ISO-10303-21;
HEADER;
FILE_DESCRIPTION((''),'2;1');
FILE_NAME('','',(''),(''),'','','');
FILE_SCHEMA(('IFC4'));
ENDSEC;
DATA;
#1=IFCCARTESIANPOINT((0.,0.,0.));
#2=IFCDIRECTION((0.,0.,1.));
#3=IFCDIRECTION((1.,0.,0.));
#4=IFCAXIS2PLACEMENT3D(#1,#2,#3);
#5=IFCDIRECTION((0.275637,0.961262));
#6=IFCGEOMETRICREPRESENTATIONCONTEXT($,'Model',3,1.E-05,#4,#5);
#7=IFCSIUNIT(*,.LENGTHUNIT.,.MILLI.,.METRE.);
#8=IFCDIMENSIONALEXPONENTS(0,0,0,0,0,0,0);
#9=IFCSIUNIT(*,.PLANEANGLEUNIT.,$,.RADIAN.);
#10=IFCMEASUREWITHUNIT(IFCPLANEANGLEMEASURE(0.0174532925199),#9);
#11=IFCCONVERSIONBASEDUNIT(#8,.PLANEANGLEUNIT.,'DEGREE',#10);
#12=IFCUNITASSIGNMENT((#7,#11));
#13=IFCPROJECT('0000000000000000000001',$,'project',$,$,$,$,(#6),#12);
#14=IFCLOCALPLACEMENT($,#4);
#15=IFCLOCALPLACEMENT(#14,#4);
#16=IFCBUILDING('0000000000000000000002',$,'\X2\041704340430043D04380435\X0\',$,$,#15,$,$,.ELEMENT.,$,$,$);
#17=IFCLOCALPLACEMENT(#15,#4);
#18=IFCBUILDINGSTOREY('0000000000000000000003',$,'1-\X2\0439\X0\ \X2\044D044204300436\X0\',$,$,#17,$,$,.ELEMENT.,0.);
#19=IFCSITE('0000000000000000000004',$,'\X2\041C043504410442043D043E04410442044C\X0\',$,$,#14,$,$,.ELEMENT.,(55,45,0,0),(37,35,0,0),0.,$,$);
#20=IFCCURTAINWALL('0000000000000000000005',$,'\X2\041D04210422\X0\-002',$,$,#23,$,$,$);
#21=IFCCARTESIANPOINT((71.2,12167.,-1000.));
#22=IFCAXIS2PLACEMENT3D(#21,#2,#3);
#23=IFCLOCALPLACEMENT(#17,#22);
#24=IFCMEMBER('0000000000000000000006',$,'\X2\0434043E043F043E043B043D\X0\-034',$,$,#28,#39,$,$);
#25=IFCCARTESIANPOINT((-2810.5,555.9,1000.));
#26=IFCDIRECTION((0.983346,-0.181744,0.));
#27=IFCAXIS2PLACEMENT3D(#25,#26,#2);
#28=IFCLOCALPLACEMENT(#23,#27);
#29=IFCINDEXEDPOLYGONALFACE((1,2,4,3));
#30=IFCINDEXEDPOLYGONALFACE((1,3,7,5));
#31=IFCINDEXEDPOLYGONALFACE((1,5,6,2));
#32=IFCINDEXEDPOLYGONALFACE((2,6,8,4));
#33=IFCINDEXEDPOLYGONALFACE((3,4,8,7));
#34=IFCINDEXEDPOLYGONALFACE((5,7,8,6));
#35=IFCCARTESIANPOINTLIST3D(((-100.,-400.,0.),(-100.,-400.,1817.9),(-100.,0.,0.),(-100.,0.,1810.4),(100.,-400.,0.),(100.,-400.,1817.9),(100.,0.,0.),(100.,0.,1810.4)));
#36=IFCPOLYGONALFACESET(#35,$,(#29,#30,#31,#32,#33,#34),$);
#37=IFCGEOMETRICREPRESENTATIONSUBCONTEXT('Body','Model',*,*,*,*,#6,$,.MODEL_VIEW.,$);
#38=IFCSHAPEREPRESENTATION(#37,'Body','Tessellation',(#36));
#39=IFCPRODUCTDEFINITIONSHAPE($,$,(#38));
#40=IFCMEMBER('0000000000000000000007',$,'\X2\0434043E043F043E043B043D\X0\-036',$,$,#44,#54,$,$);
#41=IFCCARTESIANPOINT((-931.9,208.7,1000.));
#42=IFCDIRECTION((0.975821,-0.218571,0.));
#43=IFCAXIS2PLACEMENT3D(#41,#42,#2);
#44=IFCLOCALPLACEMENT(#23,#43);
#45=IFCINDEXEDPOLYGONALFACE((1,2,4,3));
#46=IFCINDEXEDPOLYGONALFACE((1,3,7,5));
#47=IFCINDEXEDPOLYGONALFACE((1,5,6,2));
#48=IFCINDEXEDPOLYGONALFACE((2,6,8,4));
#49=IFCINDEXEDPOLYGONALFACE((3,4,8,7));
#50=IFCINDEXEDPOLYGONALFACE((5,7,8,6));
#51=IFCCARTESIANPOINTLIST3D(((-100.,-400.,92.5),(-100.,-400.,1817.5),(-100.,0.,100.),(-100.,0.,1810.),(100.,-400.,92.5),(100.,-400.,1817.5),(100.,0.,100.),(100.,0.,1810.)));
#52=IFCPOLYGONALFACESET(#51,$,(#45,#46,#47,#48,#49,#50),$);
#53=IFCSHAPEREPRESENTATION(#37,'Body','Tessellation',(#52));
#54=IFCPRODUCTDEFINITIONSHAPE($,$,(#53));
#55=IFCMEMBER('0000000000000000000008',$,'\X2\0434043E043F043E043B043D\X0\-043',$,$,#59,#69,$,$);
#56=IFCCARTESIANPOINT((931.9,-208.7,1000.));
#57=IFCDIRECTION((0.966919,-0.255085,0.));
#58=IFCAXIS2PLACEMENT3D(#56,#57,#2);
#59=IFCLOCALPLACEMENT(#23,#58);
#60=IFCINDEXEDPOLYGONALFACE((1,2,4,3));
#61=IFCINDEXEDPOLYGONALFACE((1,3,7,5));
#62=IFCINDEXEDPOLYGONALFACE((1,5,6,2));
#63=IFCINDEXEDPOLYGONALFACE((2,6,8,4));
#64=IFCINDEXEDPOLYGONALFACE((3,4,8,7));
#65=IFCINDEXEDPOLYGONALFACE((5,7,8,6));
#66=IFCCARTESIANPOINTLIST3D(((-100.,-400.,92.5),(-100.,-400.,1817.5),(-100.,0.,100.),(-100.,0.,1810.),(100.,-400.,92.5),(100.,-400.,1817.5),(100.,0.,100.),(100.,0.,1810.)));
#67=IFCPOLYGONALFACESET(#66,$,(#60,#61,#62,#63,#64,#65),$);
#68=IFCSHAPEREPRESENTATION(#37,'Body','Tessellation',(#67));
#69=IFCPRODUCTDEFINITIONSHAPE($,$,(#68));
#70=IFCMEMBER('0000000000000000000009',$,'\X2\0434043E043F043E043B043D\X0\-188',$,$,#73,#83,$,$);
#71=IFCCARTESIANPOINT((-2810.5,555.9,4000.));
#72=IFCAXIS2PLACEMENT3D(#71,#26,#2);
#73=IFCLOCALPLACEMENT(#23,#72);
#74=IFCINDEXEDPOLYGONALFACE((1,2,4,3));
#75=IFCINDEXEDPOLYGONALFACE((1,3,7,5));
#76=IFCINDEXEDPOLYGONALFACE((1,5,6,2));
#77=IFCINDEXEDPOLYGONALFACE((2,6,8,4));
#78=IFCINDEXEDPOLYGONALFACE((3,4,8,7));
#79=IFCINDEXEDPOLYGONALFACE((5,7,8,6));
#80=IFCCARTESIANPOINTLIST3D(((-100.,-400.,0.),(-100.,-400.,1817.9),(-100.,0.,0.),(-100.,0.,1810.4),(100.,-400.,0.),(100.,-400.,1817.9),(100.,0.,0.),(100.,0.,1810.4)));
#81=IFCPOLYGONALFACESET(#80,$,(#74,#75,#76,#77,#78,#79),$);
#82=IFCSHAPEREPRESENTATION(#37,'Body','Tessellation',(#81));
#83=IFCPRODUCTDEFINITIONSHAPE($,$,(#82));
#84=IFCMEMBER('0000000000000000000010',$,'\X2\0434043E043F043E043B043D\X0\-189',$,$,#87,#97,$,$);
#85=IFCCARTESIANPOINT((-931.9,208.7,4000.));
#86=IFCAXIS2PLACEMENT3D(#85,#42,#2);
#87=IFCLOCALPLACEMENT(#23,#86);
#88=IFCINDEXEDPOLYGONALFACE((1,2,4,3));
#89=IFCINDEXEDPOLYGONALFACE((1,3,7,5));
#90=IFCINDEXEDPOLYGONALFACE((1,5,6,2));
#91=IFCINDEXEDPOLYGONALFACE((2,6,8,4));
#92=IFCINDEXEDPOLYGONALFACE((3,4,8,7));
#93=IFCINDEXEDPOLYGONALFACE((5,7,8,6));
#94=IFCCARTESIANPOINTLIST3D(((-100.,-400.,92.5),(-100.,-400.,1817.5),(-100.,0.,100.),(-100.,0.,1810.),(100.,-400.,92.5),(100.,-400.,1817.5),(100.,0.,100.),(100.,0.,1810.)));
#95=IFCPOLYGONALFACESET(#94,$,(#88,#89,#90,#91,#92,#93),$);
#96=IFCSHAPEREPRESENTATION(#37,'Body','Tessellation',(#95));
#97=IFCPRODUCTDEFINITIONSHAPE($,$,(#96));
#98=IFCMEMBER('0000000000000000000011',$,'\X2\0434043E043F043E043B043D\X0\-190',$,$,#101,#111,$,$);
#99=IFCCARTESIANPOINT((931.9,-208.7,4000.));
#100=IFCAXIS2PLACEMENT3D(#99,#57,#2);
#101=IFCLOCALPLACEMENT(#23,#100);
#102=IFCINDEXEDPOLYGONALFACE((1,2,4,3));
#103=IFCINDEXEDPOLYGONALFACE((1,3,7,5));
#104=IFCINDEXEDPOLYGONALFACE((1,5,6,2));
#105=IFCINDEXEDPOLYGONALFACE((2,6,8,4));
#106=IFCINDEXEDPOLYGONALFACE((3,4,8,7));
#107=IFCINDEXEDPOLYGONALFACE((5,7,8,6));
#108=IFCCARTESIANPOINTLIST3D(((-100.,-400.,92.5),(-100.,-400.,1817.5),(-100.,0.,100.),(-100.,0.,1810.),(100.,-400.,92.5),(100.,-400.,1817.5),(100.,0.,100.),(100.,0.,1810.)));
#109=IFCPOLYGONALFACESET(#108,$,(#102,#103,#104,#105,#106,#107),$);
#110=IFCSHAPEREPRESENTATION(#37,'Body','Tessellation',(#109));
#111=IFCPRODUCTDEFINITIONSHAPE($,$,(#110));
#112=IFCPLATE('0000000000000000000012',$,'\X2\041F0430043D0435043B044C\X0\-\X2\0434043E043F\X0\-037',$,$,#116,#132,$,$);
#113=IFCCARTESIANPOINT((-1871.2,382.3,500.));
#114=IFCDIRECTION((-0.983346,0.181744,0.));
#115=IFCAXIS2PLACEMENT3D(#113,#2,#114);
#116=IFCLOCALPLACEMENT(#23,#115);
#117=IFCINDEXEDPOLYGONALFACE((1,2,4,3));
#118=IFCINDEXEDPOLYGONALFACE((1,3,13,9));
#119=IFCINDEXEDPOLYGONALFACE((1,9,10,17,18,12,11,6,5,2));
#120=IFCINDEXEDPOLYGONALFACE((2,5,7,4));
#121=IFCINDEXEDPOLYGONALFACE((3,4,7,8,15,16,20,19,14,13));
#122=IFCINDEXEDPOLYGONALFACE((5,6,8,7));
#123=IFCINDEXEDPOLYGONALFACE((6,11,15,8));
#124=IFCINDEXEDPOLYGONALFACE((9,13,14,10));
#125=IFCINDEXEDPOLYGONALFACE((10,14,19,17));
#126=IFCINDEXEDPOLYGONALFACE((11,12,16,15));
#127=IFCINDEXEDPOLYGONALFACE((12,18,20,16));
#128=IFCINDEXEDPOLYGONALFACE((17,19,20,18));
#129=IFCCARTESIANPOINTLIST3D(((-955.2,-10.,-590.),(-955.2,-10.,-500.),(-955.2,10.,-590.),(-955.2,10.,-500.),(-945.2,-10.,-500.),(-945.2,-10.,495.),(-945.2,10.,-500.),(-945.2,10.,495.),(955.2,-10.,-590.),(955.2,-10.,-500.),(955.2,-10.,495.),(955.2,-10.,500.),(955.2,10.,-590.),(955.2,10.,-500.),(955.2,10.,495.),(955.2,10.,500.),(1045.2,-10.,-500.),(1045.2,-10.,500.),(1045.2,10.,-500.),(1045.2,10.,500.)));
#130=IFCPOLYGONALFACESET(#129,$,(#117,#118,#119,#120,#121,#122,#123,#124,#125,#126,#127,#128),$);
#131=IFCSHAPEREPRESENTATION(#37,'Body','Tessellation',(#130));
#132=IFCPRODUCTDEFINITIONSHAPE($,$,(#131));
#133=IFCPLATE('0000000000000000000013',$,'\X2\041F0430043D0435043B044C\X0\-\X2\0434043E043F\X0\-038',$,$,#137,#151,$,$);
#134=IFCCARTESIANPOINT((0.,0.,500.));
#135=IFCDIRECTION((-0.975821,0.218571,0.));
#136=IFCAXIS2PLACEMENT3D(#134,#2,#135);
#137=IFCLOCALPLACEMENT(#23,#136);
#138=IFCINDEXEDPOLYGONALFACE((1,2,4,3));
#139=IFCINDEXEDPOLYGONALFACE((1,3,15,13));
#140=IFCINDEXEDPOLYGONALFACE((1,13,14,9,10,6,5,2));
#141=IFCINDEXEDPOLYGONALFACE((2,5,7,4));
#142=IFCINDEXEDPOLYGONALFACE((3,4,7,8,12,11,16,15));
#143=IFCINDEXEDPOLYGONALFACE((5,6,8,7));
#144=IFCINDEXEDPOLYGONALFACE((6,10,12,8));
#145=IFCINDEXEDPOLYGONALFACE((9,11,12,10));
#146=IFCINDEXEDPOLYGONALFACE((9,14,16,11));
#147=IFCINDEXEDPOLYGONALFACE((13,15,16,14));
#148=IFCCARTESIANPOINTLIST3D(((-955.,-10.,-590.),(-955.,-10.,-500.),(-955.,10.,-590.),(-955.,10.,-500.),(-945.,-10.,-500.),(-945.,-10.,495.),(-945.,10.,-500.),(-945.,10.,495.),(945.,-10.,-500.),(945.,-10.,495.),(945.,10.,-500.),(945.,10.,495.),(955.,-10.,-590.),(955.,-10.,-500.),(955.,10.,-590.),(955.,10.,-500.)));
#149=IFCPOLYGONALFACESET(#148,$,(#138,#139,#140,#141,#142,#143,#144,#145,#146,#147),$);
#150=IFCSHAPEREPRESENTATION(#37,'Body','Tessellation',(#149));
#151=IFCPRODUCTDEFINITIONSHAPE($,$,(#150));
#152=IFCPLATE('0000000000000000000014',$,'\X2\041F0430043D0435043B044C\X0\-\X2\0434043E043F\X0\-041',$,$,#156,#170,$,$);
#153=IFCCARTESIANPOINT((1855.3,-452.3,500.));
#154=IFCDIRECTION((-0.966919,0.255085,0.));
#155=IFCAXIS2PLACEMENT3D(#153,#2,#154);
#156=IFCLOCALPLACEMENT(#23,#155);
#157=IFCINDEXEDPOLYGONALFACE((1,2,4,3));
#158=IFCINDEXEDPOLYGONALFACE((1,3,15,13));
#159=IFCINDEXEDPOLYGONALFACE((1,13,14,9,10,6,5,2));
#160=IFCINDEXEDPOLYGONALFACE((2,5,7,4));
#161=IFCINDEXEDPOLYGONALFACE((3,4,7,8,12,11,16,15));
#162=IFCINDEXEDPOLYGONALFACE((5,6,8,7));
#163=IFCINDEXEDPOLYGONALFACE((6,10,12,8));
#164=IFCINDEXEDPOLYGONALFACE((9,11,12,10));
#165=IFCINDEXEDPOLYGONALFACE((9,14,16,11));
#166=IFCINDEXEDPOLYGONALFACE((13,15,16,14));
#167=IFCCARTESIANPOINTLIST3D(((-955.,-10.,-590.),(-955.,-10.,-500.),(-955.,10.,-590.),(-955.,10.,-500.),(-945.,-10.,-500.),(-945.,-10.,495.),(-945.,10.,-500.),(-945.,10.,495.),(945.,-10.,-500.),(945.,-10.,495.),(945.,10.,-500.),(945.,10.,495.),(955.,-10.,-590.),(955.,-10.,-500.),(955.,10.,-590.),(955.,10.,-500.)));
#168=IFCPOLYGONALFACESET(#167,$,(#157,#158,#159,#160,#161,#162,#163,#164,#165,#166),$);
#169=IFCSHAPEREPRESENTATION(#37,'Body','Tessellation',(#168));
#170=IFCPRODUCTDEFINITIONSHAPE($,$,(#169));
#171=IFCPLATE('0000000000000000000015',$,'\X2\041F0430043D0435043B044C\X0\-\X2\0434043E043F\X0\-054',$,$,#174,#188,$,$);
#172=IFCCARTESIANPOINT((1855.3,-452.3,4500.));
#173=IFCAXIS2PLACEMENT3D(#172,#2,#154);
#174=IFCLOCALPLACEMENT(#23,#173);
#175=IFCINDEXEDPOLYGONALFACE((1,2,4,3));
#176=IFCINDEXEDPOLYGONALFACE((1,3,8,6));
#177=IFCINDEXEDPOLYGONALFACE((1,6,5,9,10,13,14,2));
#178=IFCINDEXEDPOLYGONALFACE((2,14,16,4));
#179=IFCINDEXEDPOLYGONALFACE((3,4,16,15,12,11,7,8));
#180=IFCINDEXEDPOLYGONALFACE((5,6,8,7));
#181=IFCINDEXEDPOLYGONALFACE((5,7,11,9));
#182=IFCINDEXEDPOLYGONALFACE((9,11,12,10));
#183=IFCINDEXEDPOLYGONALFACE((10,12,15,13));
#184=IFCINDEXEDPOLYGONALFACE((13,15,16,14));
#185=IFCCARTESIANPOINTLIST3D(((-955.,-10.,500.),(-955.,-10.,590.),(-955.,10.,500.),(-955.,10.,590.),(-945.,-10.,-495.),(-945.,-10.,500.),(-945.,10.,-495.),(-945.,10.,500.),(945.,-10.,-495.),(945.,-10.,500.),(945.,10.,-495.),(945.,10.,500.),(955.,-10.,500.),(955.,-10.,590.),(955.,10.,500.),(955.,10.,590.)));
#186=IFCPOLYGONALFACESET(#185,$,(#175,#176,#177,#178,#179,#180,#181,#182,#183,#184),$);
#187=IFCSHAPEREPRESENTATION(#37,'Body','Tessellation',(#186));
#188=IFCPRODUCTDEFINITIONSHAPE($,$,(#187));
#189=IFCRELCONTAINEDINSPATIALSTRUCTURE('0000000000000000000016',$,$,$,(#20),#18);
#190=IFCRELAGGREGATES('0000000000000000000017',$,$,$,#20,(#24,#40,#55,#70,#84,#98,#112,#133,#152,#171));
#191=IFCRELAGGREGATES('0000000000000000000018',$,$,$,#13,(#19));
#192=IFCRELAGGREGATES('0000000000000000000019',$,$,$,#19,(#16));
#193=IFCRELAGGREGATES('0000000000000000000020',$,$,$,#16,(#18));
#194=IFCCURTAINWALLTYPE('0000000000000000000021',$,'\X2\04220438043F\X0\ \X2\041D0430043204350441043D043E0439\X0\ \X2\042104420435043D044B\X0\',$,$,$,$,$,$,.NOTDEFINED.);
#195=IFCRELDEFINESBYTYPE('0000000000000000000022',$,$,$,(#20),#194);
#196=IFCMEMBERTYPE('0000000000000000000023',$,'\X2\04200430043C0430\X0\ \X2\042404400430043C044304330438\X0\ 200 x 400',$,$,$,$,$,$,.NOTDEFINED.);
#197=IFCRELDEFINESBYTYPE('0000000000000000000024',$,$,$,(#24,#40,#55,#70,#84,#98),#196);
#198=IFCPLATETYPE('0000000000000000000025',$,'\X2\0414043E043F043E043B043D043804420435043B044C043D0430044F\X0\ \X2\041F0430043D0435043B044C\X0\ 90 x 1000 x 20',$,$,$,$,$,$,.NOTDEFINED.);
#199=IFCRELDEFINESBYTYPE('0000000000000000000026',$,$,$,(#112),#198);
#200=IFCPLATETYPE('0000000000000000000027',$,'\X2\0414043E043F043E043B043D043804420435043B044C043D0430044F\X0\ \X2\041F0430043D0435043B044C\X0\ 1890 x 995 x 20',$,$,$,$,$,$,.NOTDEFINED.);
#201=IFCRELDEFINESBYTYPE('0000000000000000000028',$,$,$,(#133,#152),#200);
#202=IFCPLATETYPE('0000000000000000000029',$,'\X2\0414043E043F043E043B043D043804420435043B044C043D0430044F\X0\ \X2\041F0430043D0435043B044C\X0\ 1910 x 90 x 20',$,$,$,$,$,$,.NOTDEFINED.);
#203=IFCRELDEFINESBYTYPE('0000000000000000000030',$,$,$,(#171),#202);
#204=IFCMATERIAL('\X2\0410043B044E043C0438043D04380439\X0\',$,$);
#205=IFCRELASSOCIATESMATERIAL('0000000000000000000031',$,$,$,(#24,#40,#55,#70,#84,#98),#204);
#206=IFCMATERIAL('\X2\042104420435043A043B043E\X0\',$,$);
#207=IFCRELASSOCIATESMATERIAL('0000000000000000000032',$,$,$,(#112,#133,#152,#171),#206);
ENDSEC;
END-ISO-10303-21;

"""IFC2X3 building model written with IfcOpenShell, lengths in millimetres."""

from ifc_helpers import new_model, entity, si_unit, converted_unit, direction, frame, origin_with_axes, place, context, subcontext, project, spatial, polyline, outline, extrude, clip, halfspace, material, type_object, element, aggregate, save


model = new_model("IFC2X3")

# Units and contexts
model_context = context("Model", 3, precision=1e-05, world=origin_with_axes(), true_north=direction((0.275637, 0.961262)))
body_context = subcontext(model_context, "Body", "Model", "MODEL_VIEW")
ifc_project = project(units=[si_unit("LENGTHUNIT", "METRE", prefix="MILLI"), converted_unit("PLANEANGLEUNIT", "DEGREE", entity("IfcPlaneAngleMeasure", 0.0174532925199), si_unit("PLANEANGLEUNIT", "RADIAN"), dimensions=[0, 0, 0, 0, 0, 0, 0])], contexts=[model_context])

# Site, building, storey
site_placement = place(None, origin_with_axes())
site = spatial("IfcSite", under=ifc_project, at=site_placement, Name="Местность", CompositionType="ELEMENT", RefLatitude=(55, 45, 0, 0), RefLongitude=(37, 35, 0, 0), RefElevation=0.0)
building_placement = place(site_placement, origin_with_axes())
building = spatial("IfcBuilding", under=site, at=building_placement, Name="Здание", CompositionType="ELEMENT")
storey_placement = place(building_placement, origin_with_axes())
storey = spatial("IfcBuildingStorey", under=building, at=storey_placement, Name="1-й этаж", CompositionType="ELEMENT", Elevation=0.0)

# Curtain wall, members, plates
curtain_wall_type = type_object("IfcCurtainWallType", Name="Тип Навесной Стены", PredefinedType="NOTDEFINED")
curtain_wall_placement = place(storey_placement, frame((71.2, 12167.0, -1000.0), z_axis=(0.0, 0.0, 1.0), x_axis=(1.0, 0.0, 0.0)))
curtain_wall = element("IfcCurtainWall", 1, at=curtain_wall_placement, inside=storey, type_object=curtain_wall_type, Name="НСТ-002")
ifc_material_1 = material(Name="Алюминий")
member_type_1 = type_object("IfcMemberType", Name="Рама Фрамуги 200 x 400", PredefinedType="NOTDEFINED")
member_1_placement = place(curtain_wall_placement, frame((-2810.5, 555.9, 1000.0), z_axis=(0.983346, -0.181744, 0.0), x_axis=(0.0, 0.0, 1.0)))
member_1 = element("IfcMember", 2, at=member_1_placement, type_object=member_type_1, material=ifc_material_1, Name="дополн-034", context=body_context, shape_type="Clipping", body=[
    clip(extrude(outline(polyline([(-400.0, -100.0), (0.0, -100.0), (0.0, 100.0), (-400.0, 100.0), (-400.0, -100.0)])), frame((0.0, 0.0, 0.0), z_axis=(0.0, 0.0, 1.0), x_axis=(0.0, 1.0, 0.0)), (0.0, 0.0, 1.0), 1817.9), halfspace(frame((0.0, 34.0, 1809.7), z_axis=(0.0, -0.018794, -0.999823), x_axis=(0.0, 0.999823, -0.018794)), True)),
])
member_2_placement = place(curtain_wall_placement, frame((-931.9, 208.7, 1000.0), z_axis=(0.975821, -0.218571, 0.0), x_axis=(0.0, 0.0, 1.0)))
member_2 = element("IfcMember", 3, at=member_2_placement, type_object=member_type_1, material=ifc_material_1, Name="дополн-036", context=body_context, shape_type="Clipping", body=[
    clip(clip(extrude(outline(polyline([(-400.0, -100.0), (0.0, -100.0), (0.0, 100.0), (-400.0, 100.0), (-400.0, -100.0)])), frame((0.0, 0.0, 92.5), z_axis=(0.0, 0.0, 1.0), x_axis=(0.0, 1.0, 0.0)), (0.0, 0.0, 1.0), 1725.0), halfspace(frame((0.0, 34.0, 1809.3), z_axis=(0.0, -0.018792, -0.999823), x_axis=(0.0, 0.999823, -0.018792)), True)), halfspace(frame((0.0, -1.9, 100.0), z_axis=(0.0, -0.018794, 0.999823), x_axis=(0.0, -0.999823, -0.018794)), True)),
])
member_3_placement = place(curtain_wall_placement, frame((931.9, -208.7, 1000.0), z_axis=(0.966919, -0.255085, 0.0), x_axis=(0.0, 0.0, 1.0)))
member_3 = element("IfcMember", 4, at=member_3_placement, type_object=member_type_1, material=ifc_material_1, Name="дополн-043", context=body_context, shape_type="Clipping", body=[
    clip(clip(extrude(outline(polyline([(-400.0, -100.0), (0.0, -100.0), (0.0, 100.0), (-400.0, 100.0), (-400.0, -100.0)])), frame((0.0, 0.0, 92.5), z_axis=(0.0, 0.0, 1.0), x_axis=(0.0, 1.0, 0.0)), (0.0, 0.0, 1.0), 1725.0), halfspace(frame((0.0, 34.0, 1809.3), z_axis=(0.0, -0.018792, -0.999823), x_axis=(0.0, 0.999823, -0.018792)), True)), halfspace(frame((0.0, -1.9, 100.0), z_axis=(0.0, -0.018792, 0.999823), x_axis=(0.0, -0.999823, -0.018792)), True)),
])
member_4_placement = place(curtain_wall_placement, frame((-2810.5, 555.9, 4000.0), z_axis=(0.983346, -0.181744, 0.0), x_axis=(0.0, 0.0, 1.0)))
member_4 = element("IfcMember", 5, at=member_4_placement, type_object=member_type_1, material=ifc_material_1, Name="дополн-188", context=body_context, shape_type="Clipping", body=[
    clip(extrude(outline(polyline([(-400.0, -100.0), (0.0, -100.0), (0.0, 100.0), (-400.0, 100.0), (-400.0, -100.0)])), frame((0.0, 0.0, 0.0), z_axis=(0.0, 0.0, 1.0), x_axis=(0.0, 1.0, 0.0)), (0.0, 0.0, 1.0), 1817.9), halfspace(frame((0.0, 34.0, 1809.7), z_axis=(0.0, -0.018794, -0.999823), x_axis=(0.0, 0.999823, -0.018794)), True)),
])
member_5_placement = place(curtain_wall_placement, frame((-931.9, 208.7, 4000.0), z_axis=(0.975821, -0.218571, 0.0), x_axis=(0.0, 0.0, 1.0)))
member_5 = element("IfcMember", 6, at=member_5_placement, type_object=member_type_1, material=ifc_material_1, Name="дополн-189", context=body_context, shape_type="Clipping", body=[
    clip(clip(extrude(outline(polyline([(-400.0, -100.0), (0.0, -100.0), (0.0, 100.0), (-400.0, 100.0), (-400.0, -100.0)])), frame((0.0, 0.0, 92.5), z_axis=(0.0, 0.0, 1.0), x_axis=(0.0, 1.0, 0.0)), (0.0, 0.0, 1.0), 1725.0), halfspace(frame((0.0, 34.0, 1809.3), z_axis=(0.0, -0.018792, -0.999823), x_axis=(0.0, 0.999823, -0.018792)), True)), halfspace(frame((0.0, -1.9, 100.0), z_axis=(0.0, -0.018794, 0.999823), x_axis=(0.0, -0.999823, -0.018794)), True)),
])
member_6_placement = place(curtain_wall_placement, frame((931.9, -208.7, 4000.0), z_axis=(0.966919, -0.255085, 0.0), x_axis=(0.0, 0.0, 1.0)))
member_6 = element("IfcMember", 7, at=member_6_placement, type_object=member_type_1, material=ifc_material_1, Name="дополн-190", context=body_context, shape_type="Clipping", body=[
    clip(clip(extrude(outline(polyline([(-400.0, -100.0), (0.0, -100.0), (0.0, 100.0), (-400.0, 100.0), (-400.0, -100.0)])), frame((0.0, 0.0, 92.5), z_axis=(0.0, 0.0, 1.0), x_axis=(0.0, 1.0, 0.0)), (0.0, 0.0, 1.0), 1725.0), halfspace(frame((0.0, 34.0, 1809.3), z_axis=(0.0, -0.018792, -0.999823), x_axis=(0.0, 0.999823, -0.018792)), True)), halfspace(frame((0.0, -1.9, 100.0), z_axis=(0.0, -0.018792, 0.999823), x_axis=(0.0, -0.999823, -0.018792)), True)),
])
ifc_material_2 = material(Name="Стекло")
plate_type_1 = type_object("IfcPlateType", Name="Дополнительная Панель 90 x 1000 x 20", PredefinedType="NOTDEFINED")
plate_1_placement = place(curtain_wall_placement, frame((-1871.2, 382.3, 500.0), z_axis=(0.0, 0.0, 1.0), x_axis=(-0.983346, 0.181744, 0.0)))
plate_1 = element("IfcPlate", 8, at=plate_1_placement, type_object=plate_type_1, material=ifc_material_2, Name="Панель-доп-037", context=body_context, shape_type="SweptSolid", body=[
    extrude(outline(polyline([(955.2, -500.0), (1045.2, -500.0), (1045.2, 500.0), (955.2, 500.0), (955.2, 590.0), (-955.2, 590.0), (-955.2, 500.0), (-945.2, 500.0), (-945.2, -495.0), (955.2, -495.0), (955.2, -500.0)])), frame((0.0, -10.0, 0.0), z_axis=(0.0, 1.0, 0.0), x_axis=(1.0, 0.0, 0.0)), (0.0, 0.0, 1.0), 20.0),
])
plate_type_2 = type_object("IfcPlateType", Name="Дополнительная Панель 1890 x 995 x 20", PredefinedType="NOTDEFINED")
plate_2_placement = place(curtain_wall_placement, frame((0.0, 0.0, 500.0), z_axis=(0.0, 0.0, 1.0), x_axis=(-0.975821, 0.218571, 0.0)))
plate_2 = element("IfcPlate", 9, at=plate_2_placement, type_object=plate_type_2, material=ifc_material_2, Name="Панель-доп-038", context=body_context, shape_type="SweptSolid", body=[
    extrude(outline(polyline([(-945.0, -495.0), (945.0, -495.0), (945.0, 500.0), (955.0, 500.0), (955.0, 590.0), (-955.0, 590.0), (-955.0, 500.0), (-945.0, 500.0), (-945.0, -495.0)])), frame((0.0, -10.0, 0.0), z_axis=(0.0, 1.0, 0.0), x_axis=(1.0, 0.0, 0.0)), (0.0, 0.0, 1.0), 20.0),
])
plate_3_placement = place(curtain_wall_placement, frame((1855.3, -452.3, 500.0), z_axis=(0.0, 0.0, 1.0), x_axis=(-0.966919, 0.255085, 0.0)))
plate_3 = element("IfcPlate", 10, at=plate_3_placement, type_object=plate_type_2, material=ifc_material_2, Name="Панель-доп-041", context=body_context, shape_type="SweptSolid", body=[
    extrude(outline(polyline([(-945.0, -495.0), (945.0, -495.0), (945.0, 500.0), (955.0, 500.0), (955.0, 590.0), (-955.0, 590.0), (-955.0, 500.0), (-945.0, 500.0), (-945.0, -495.0)])), frame((0.0, -10.0, 0.0), z_axis=(0.0, 1.0, 0.0), x_axis=(1.0, 0.0, 0.0)), (0.0, 0.0, 1.0), 20.0),
])
plate_type_3 = type_object("IfcPlateType", Name="Дополнительная Панель 1910 x 90 x 20", PredefinedType="NOTDEFINED")
plate_4_placement = place(curtain_wall_placement, frame((1855.3, -452.3, 4500.0), z_axis=(0.0, 0.0, 1.0), x_axis=(-0.966919, 0.255085, 0.0)))
plate_4 = element("IfcPlate", 11, at=plate_4_placement, type_object=plate_type_3, material=ifc_material_2, Name="Панель-доп-054", context=body_context, shape_type="SweptSolid", body=[
    extrude(outline(polyline([(-955.0, -590.0), (955.0, -590.0), (955.0, -500.0), (945.0, -500.0), (945.0, 495.0), (-945.0, 495.0), (-945.0, -500.0), (-955.0, -500.0), (-955.0, -590.0)])), frame((0.0, -10.0, 0.0), z_axis=(0.0, 1.0, 0.0), x_axis=(1.0, 0.0, 0.0)), (0.0, 0.0, 1.0), 20.0),
])
aggregate(curtain_wall, [member_1, member_2, member_3, member_4, member_5, member_6, plate_1, plate_2, plate_3, plate_4])

save(model, "model.ifc")
